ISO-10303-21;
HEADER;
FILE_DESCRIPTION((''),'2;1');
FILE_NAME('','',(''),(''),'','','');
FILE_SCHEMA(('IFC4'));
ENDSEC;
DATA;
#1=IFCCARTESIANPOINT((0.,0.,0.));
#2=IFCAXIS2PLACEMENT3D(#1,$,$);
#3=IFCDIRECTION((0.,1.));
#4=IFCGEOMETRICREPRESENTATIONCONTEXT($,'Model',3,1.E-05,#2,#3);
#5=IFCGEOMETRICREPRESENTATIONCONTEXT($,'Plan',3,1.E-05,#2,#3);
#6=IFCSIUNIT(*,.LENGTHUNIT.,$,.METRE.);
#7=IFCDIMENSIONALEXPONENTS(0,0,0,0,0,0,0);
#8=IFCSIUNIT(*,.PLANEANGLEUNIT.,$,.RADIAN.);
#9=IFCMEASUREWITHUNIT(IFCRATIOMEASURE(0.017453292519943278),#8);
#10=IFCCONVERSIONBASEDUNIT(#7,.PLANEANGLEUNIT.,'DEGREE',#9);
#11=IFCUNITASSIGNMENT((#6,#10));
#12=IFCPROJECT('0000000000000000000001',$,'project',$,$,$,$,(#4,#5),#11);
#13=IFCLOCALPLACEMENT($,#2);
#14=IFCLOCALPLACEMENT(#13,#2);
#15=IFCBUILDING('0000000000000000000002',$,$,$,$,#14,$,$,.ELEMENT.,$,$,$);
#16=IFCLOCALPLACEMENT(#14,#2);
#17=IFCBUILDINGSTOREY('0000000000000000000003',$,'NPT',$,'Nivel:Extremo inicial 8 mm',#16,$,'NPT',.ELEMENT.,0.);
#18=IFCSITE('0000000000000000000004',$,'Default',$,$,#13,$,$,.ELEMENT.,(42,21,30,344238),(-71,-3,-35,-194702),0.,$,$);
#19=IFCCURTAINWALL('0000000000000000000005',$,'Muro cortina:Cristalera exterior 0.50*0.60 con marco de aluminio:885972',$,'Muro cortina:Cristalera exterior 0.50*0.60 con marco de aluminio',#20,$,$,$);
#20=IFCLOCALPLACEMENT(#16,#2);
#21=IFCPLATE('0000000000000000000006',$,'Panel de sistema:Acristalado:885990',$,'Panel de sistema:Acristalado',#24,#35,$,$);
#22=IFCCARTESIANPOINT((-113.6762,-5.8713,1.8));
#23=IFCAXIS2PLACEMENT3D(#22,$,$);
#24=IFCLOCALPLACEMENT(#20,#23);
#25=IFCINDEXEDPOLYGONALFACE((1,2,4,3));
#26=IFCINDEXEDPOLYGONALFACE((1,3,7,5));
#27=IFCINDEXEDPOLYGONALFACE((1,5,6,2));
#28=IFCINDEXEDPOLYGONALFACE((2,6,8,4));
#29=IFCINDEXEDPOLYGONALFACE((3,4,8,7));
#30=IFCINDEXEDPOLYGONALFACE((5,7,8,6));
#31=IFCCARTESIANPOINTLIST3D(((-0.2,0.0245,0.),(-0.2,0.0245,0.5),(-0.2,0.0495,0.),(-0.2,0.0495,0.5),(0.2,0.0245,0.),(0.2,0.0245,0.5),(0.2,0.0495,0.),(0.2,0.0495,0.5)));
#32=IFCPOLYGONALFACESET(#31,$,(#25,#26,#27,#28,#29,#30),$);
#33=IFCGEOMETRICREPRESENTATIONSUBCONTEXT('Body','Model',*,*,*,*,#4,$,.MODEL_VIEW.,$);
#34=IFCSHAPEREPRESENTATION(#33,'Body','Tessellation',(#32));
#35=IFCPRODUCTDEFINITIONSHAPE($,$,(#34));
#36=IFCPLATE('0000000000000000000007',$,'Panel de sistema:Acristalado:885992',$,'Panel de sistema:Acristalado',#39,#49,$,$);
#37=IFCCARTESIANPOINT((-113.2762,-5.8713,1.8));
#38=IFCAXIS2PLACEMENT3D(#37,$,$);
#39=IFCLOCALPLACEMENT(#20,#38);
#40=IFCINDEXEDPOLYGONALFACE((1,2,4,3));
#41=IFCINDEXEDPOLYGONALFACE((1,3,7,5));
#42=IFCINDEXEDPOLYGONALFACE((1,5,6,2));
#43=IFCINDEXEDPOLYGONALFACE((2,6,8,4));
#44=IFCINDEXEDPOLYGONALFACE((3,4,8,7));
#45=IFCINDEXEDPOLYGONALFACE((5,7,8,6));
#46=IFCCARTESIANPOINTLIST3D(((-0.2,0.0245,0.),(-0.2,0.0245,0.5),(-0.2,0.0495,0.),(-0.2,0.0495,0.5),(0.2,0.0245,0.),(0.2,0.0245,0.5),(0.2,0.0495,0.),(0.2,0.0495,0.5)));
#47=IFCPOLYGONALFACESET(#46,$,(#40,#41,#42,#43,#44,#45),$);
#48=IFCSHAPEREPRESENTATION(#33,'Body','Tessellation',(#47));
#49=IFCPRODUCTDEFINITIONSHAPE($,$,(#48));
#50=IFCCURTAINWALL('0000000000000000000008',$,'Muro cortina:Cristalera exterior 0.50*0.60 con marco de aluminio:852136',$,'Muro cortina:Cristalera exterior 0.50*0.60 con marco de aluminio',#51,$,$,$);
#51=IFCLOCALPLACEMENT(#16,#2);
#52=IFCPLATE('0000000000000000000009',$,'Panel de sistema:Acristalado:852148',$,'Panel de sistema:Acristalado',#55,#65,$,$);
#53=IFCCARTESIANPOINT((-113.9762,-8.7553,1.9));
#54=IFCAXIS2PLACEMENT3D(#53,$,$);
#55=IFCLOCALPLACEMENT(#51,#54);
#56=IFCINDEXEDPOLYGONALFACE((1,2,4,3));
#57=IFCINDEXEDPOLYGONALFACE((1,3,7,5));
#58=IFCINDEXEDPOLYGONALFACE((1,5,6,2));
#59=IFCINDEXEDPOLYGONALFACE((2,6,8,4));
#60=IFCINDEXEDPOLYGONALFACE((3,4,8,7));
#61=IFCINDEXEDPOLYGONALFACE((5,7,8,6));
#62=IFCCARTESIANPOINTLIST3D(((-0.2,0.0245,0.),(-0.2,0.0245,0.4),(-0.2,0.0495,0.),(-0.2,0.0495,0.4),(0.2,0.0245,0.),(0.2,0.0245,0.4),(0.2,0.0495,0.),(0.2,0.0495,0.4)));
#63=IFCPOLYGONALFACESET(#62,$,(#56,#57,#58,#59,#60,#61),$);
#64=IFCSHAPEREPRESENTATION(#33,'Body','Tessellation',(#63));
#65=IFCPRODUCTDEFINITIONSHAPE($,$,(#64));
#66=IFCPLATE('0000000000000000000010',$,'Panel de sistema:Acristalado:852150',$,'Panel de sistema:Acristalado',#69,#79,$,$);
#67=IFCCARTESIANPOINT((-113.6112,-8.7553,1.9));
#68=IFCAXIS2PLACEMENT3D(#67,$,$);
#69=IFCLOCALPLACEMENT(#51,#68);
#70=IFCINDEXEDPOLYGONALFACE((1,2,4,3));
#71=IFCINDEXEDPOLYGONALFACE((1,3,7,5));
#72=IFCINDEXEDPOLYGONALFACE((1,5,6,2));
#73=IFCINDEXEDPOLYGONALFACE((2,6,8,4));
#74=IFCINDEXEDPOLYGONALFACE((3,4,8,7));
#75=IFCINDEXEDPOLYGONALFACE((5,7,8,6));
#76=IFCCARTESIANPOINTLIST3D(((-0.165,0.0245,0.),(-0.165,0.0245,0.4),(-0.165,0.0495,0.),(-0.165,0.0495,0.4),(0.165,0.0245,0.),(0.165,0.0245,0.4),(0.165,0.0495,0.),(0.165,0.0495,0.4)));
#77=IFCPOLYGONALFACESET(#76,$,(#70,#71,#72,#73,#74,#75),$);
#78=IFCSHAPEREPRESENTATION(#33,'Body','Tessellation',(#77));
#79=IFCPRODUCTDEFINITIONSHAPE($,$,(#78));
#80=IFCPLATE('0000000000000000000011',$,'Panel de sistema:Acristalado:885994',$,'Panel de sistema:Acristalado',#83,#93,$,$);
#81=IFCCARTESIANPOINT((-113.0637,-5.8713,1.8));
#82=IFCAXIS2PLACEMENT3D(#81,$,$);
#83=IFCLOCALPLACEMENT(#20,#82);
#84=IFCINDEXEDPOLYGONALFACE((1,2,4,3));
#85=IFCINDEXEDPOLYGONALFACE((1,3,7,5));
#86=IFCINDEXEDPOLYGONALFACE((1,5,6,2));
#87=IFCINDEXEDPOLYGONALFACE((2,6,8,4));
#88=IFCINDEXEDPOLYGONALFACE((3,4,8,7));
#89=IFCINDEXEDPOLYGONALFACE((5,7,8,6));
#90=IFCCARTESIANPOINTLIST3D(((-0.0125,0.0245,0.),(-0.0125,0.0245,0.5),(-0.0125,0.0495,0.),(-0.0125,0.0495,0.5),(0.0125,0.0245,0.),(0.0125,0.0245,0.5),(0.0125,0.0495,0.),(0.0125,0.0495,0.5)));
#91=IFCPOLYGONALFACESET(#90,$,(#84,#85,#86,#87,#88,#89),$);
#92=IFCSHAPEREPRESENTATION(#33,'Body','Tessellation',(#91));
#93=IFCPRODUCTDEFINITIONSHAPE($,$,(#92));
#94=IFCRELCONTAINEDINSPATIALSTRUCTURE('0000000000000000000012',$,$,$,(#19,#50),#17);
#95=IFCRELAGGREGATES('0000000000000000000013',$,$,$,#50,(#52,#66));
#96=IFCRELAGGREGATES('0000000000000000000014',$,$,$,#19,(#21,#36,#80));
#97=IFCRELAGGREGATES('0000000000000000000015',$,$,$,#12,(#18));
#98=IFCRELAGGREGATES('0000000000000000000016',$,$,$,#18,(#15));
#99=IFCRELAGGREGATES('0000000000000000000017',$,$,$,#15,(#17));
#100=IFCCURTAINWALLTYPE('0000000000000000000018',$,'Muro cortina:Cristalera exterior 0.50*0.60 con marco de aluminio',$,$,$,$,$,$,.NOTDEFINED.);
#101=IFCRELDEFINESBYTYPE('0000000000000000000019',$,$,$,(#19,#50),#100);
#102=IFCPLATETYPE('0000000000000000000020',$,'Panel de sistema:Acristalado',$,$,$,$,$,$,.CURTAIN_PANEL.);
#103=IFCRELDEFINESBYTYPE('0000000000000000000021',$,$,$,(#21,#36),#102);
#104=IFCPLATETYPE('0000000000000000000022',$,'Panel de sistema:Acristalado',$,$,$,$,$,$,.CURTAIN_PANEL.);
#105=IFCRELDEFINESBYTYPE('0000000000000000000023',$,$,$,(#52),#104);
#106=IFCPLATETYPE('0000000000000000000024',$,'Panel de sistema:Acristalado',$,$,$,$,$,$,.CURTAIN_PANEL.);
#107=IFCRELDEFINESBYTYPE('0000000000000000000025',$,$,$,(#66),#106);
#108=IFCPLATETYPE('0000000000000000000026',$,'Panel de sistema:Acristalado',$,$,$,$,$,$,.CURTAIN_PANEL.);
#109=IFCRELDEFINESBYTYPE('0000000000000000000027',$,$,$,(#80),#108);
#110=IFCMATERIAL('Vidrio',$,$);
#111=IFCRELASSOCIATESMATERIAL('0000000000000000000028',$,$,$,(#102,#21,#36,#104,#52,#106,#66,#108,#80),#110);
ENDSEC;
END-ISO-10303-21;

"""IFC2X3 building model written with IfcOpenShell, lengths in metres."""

from ifc_helpers import new_model, entity, si_unit, converted_unit, direction, frame, origin, origin_2d_with_axis, place, context, subcontext, project, spatial, rectangle, extrude, source, transform, mapped, material, type_object, type_shapes, element, aggregate, save


model = new_model("IFC2X3")

# Units and contexts
model_context = context("Model", 3, precision=1e-05, world=origin(), true_north=direction((0.0, 1.0)))
plan_context = context("Plan", 3, precision=1e-05, world=origin(), true_north=direction((0.0, 1.0)))
body_context = subcontext(model_context, "Body", "Model", "MODEL_VIEW")
ifc_project = project(units=[si_unit("LENGTHUNIT", "METRE"), converted_unit("PLANEANGLEUNIT", "DEGREE", entity("IfcRatioMeasure", 0.017453292519943278), si_unit("PLANEANGLEUNIT", "RADIAN"), dimensions=[0, 0, 0, 0, 0, 0, 0])], contexts=[model_context, plan_context])

# Site, building, storey
site_placement = place(None, origin())
site = spatial("IfcSite", under=ifc_project, at=site_placement, Name="Default", CompositionType="ELEMENT", RefLatitude=(42, 21, 30, 344238), RefLongitude=(-71, -3, -35, -194702), RefElevation=0.0)
building_placement = place(site_placement, origin())
building = spatial("IfcBuilding", under=site, at=building_placement, CompositionType="ELEMENT")
storey_placement = place(building_placement, origin())
storey = spatial("IfcBuildingStorey", under=building, at=storey_placement, Name="NPT", ObjectType="Nivel:Extremo inicial 8 mm", LongName="NPT", CompositionType="ELEMENT", Elevation=0.0)

# Curtain wall, plates
curtain_wall_type = type_object("IfcCurtainWallType", Name="Muro cortina:Cristalera exterior 0.50*0.60 con marco de aluminio", PredefinedType="NOTDEFINED")
curtain_wall_1_placement = place(storey_placement, origin())
curtain_wall_1 = element("IfcCurtainWall", 1, at=curtain_wall_1_placement, inside=storey, type_object=curtain_wall_type, Name="Muro cortina:Cristalera exterior 0.50*0.60 con marco de aluminio:885972", ObjectType="Muro cortina:Cristalera exterior 0.50*0.60 con marco de aluminio")
ifc_material_1 = material(Name="Vidrio")
plate_type_1 = type_object("IfcPlateType", Name="Panel de sistema:Acristalado", PredefinedType="CURTAIN_PANEL", material=ifc_material_1)
shared_shape_1 = source(origin(), body_context, "Body", "SweptSolid", [
    extrude(rectangle(XDim=0.025, YDim=0.4, at=origin_2d_with_axis()), frame((0.0, 0.037, 0.0), z_axis=(0.0, 0.0, 1.0), x_axis=(0.0, 1.0, 0.0)), (0.0, 0.0, 1.0), 0.5),
])
type_shapes(plate_type_1, [shared_shape_1])
plate_1_placement = place(curtain_wall_1_placement, frame((-113.6762, -5.8713, 1.8)))
plate_1 = element("IfcPlate", 2, at=plate_1_placement, type_object=plate_type_1, material=ifc_material_1, Name="Panel de sistema:Acristalado:885990", ObjectType="Panel de sistema:Acristalado", context=body_context, shape_type="MappedRepresentation", body=[
    mapped(shared_shape_1, transform((0.0, 0.0, 0.0), scale=1.0)),
])
plate_2_placement = place(curtain_wall_1_placement, frame((-113.2762, -5.8713, 1.8)))
plate_2 = element("IfcPlate", 3, at=plate_2_placement, type_object=plate_type_1, material=ifc_material_1, Name="Panel de sistema:Acristalado:885992", ObjectType="Panel de sistema:Acristalado", context=body_context, shape_type="MappedRepresentation", body=[
    mapped(shared_shape_1, transform((0.0, 0.0, 0.0), scale=1.0)),
])

# Curtain wall, plates
curtain_wall_2_placement = place(storey_placement, origin())
curtain_wall_2 = element("IfcCurtainWall", 4, at=curtain_wall_2_placement, inside=storey, type_object=curtain_wall_type, Name="Muro cortina:Cristalera exterior 0.50*0.60 con marco de aluminio:852136", ObjectType="Muro cortina:Cristalera exterior 0.50*0.60 con marco de aluminio")
plate_type_2 = type_object("IfcPlateType", Name="Panel de sistema:Acristalado", PredefinedType="CURTAIN_PANEL", material=ifc_material_1)
shared_shape_2 = source(origin(), body_context, "Body", "SweptSolid", [
    extrude(rectangle(XDim=0.025, YDim=0.4, at=origin_2d_with_axis()), frame((0.0, 0.037, 0.0), z_axis=(0.0, 0.0, 1.0), x_axis=(0.0, 1.0, 0.0)), (0.0, 0.0, 1.0), 0.4),
])
type_shapes(plate_type_2, [shared_shape_2])
plate_3_placement = place(curtain_wall_2_placement, frame((-113.9762, -8.7553, 1.9)))
plate_3 = element("IfcPlate", 5, at=plate_3_placement, type_object=plate_type_2, material=ifc_material_1, Name="Panel de sistema:Acristalado:852148", ObjectType="Panel de sistema:Acristalado", context=body_context, shape_type="MappedRepresentation", body=[
    mapped(shared_shape_2, transform((0.0, 0.0, 0.0), scale=1.0)),
])
plate_type_3 = type_object("IfcPlateType", Name="Panel de sistema:Acristalado", PredefinedType="CURTAIN_PANEL", material=ifc_material_1)
shared_shape_3 = source(origin(), body_context, "Body", "SweptSolid", [
    extrude(rectangle(XDim=0.025, YDim=0.33, at=origin_2d_with_axis()), frame((0.0, 0.037, 0.0), z_axis=(0.0, 0.0, 1.0), x_axis=(0.0, 1.0, 0.0)), (0.0, 0.0, 1.0), 0.4),
])
type_shapes(plate_type_3, [shared_shape_3])
plate_4_placement = place(curtain_wall_2_placement, frame((-113.6112, -8.7553, 1.9)))
plate_4 = element("IfcPlate", 6, at=plate_4_placement, type_object=plate_type_3, material=ifc_material_1, Name="Panel de sistema:Acristalado:852150", ObjectType="Panel de sistema:Acristalado", context=body_context, shape_type="MappedRepresentation", body=[
    mapped(shared_shape_3, transform((0.0, 0.0, 0.0), scale=1.0)),
])
aggregate(curtain_wall_2, [plate_3, plate_4])

# Plate
plate_type_4 = type_object("IfcPlateType", Name="Panel de sistema:Acristalado", PredefinedType="CURTAIN_PANEL", material=ifc_material_1)
shared_shape_4 = source(origin(), body_context, "Body", "SweptSolid", [
    extrude(rectangle(XDim=0.025, YDim=0.025, at=origin_2d_with_axis()), frame((0.0, 0.037, 0.0), z_axis=(0.0, 0.0, 1.0), x_axis=(0.0, 1.0, 0.0)), (0.0, 0.0, 1.0), 0.5),
])
type_shapes(plate_type_4, [shared_shape_4])
plate_5_placement = place(curtain_wall_1_placement, frame((-113.0637, -5.8713, 1.8)))
plate_5 = element("IfcPlate", 7, at=plate_5_placement, type_object=plate_type_4, material=ifc_material_1, Name="Panel de sistema:Acristalado:885994", ObjectType="Panel de sistema:Acristalado", context=body_context, shape_type="MappedRepresentation", body=[
    mapped(shared_shape_4, transform((0.0, 0.0, 0.0), scale=1.0)),
])
aggregate(curtain_wall_1, [plate_1, plate_2, plate_5])

save(model, "model.ifc")
